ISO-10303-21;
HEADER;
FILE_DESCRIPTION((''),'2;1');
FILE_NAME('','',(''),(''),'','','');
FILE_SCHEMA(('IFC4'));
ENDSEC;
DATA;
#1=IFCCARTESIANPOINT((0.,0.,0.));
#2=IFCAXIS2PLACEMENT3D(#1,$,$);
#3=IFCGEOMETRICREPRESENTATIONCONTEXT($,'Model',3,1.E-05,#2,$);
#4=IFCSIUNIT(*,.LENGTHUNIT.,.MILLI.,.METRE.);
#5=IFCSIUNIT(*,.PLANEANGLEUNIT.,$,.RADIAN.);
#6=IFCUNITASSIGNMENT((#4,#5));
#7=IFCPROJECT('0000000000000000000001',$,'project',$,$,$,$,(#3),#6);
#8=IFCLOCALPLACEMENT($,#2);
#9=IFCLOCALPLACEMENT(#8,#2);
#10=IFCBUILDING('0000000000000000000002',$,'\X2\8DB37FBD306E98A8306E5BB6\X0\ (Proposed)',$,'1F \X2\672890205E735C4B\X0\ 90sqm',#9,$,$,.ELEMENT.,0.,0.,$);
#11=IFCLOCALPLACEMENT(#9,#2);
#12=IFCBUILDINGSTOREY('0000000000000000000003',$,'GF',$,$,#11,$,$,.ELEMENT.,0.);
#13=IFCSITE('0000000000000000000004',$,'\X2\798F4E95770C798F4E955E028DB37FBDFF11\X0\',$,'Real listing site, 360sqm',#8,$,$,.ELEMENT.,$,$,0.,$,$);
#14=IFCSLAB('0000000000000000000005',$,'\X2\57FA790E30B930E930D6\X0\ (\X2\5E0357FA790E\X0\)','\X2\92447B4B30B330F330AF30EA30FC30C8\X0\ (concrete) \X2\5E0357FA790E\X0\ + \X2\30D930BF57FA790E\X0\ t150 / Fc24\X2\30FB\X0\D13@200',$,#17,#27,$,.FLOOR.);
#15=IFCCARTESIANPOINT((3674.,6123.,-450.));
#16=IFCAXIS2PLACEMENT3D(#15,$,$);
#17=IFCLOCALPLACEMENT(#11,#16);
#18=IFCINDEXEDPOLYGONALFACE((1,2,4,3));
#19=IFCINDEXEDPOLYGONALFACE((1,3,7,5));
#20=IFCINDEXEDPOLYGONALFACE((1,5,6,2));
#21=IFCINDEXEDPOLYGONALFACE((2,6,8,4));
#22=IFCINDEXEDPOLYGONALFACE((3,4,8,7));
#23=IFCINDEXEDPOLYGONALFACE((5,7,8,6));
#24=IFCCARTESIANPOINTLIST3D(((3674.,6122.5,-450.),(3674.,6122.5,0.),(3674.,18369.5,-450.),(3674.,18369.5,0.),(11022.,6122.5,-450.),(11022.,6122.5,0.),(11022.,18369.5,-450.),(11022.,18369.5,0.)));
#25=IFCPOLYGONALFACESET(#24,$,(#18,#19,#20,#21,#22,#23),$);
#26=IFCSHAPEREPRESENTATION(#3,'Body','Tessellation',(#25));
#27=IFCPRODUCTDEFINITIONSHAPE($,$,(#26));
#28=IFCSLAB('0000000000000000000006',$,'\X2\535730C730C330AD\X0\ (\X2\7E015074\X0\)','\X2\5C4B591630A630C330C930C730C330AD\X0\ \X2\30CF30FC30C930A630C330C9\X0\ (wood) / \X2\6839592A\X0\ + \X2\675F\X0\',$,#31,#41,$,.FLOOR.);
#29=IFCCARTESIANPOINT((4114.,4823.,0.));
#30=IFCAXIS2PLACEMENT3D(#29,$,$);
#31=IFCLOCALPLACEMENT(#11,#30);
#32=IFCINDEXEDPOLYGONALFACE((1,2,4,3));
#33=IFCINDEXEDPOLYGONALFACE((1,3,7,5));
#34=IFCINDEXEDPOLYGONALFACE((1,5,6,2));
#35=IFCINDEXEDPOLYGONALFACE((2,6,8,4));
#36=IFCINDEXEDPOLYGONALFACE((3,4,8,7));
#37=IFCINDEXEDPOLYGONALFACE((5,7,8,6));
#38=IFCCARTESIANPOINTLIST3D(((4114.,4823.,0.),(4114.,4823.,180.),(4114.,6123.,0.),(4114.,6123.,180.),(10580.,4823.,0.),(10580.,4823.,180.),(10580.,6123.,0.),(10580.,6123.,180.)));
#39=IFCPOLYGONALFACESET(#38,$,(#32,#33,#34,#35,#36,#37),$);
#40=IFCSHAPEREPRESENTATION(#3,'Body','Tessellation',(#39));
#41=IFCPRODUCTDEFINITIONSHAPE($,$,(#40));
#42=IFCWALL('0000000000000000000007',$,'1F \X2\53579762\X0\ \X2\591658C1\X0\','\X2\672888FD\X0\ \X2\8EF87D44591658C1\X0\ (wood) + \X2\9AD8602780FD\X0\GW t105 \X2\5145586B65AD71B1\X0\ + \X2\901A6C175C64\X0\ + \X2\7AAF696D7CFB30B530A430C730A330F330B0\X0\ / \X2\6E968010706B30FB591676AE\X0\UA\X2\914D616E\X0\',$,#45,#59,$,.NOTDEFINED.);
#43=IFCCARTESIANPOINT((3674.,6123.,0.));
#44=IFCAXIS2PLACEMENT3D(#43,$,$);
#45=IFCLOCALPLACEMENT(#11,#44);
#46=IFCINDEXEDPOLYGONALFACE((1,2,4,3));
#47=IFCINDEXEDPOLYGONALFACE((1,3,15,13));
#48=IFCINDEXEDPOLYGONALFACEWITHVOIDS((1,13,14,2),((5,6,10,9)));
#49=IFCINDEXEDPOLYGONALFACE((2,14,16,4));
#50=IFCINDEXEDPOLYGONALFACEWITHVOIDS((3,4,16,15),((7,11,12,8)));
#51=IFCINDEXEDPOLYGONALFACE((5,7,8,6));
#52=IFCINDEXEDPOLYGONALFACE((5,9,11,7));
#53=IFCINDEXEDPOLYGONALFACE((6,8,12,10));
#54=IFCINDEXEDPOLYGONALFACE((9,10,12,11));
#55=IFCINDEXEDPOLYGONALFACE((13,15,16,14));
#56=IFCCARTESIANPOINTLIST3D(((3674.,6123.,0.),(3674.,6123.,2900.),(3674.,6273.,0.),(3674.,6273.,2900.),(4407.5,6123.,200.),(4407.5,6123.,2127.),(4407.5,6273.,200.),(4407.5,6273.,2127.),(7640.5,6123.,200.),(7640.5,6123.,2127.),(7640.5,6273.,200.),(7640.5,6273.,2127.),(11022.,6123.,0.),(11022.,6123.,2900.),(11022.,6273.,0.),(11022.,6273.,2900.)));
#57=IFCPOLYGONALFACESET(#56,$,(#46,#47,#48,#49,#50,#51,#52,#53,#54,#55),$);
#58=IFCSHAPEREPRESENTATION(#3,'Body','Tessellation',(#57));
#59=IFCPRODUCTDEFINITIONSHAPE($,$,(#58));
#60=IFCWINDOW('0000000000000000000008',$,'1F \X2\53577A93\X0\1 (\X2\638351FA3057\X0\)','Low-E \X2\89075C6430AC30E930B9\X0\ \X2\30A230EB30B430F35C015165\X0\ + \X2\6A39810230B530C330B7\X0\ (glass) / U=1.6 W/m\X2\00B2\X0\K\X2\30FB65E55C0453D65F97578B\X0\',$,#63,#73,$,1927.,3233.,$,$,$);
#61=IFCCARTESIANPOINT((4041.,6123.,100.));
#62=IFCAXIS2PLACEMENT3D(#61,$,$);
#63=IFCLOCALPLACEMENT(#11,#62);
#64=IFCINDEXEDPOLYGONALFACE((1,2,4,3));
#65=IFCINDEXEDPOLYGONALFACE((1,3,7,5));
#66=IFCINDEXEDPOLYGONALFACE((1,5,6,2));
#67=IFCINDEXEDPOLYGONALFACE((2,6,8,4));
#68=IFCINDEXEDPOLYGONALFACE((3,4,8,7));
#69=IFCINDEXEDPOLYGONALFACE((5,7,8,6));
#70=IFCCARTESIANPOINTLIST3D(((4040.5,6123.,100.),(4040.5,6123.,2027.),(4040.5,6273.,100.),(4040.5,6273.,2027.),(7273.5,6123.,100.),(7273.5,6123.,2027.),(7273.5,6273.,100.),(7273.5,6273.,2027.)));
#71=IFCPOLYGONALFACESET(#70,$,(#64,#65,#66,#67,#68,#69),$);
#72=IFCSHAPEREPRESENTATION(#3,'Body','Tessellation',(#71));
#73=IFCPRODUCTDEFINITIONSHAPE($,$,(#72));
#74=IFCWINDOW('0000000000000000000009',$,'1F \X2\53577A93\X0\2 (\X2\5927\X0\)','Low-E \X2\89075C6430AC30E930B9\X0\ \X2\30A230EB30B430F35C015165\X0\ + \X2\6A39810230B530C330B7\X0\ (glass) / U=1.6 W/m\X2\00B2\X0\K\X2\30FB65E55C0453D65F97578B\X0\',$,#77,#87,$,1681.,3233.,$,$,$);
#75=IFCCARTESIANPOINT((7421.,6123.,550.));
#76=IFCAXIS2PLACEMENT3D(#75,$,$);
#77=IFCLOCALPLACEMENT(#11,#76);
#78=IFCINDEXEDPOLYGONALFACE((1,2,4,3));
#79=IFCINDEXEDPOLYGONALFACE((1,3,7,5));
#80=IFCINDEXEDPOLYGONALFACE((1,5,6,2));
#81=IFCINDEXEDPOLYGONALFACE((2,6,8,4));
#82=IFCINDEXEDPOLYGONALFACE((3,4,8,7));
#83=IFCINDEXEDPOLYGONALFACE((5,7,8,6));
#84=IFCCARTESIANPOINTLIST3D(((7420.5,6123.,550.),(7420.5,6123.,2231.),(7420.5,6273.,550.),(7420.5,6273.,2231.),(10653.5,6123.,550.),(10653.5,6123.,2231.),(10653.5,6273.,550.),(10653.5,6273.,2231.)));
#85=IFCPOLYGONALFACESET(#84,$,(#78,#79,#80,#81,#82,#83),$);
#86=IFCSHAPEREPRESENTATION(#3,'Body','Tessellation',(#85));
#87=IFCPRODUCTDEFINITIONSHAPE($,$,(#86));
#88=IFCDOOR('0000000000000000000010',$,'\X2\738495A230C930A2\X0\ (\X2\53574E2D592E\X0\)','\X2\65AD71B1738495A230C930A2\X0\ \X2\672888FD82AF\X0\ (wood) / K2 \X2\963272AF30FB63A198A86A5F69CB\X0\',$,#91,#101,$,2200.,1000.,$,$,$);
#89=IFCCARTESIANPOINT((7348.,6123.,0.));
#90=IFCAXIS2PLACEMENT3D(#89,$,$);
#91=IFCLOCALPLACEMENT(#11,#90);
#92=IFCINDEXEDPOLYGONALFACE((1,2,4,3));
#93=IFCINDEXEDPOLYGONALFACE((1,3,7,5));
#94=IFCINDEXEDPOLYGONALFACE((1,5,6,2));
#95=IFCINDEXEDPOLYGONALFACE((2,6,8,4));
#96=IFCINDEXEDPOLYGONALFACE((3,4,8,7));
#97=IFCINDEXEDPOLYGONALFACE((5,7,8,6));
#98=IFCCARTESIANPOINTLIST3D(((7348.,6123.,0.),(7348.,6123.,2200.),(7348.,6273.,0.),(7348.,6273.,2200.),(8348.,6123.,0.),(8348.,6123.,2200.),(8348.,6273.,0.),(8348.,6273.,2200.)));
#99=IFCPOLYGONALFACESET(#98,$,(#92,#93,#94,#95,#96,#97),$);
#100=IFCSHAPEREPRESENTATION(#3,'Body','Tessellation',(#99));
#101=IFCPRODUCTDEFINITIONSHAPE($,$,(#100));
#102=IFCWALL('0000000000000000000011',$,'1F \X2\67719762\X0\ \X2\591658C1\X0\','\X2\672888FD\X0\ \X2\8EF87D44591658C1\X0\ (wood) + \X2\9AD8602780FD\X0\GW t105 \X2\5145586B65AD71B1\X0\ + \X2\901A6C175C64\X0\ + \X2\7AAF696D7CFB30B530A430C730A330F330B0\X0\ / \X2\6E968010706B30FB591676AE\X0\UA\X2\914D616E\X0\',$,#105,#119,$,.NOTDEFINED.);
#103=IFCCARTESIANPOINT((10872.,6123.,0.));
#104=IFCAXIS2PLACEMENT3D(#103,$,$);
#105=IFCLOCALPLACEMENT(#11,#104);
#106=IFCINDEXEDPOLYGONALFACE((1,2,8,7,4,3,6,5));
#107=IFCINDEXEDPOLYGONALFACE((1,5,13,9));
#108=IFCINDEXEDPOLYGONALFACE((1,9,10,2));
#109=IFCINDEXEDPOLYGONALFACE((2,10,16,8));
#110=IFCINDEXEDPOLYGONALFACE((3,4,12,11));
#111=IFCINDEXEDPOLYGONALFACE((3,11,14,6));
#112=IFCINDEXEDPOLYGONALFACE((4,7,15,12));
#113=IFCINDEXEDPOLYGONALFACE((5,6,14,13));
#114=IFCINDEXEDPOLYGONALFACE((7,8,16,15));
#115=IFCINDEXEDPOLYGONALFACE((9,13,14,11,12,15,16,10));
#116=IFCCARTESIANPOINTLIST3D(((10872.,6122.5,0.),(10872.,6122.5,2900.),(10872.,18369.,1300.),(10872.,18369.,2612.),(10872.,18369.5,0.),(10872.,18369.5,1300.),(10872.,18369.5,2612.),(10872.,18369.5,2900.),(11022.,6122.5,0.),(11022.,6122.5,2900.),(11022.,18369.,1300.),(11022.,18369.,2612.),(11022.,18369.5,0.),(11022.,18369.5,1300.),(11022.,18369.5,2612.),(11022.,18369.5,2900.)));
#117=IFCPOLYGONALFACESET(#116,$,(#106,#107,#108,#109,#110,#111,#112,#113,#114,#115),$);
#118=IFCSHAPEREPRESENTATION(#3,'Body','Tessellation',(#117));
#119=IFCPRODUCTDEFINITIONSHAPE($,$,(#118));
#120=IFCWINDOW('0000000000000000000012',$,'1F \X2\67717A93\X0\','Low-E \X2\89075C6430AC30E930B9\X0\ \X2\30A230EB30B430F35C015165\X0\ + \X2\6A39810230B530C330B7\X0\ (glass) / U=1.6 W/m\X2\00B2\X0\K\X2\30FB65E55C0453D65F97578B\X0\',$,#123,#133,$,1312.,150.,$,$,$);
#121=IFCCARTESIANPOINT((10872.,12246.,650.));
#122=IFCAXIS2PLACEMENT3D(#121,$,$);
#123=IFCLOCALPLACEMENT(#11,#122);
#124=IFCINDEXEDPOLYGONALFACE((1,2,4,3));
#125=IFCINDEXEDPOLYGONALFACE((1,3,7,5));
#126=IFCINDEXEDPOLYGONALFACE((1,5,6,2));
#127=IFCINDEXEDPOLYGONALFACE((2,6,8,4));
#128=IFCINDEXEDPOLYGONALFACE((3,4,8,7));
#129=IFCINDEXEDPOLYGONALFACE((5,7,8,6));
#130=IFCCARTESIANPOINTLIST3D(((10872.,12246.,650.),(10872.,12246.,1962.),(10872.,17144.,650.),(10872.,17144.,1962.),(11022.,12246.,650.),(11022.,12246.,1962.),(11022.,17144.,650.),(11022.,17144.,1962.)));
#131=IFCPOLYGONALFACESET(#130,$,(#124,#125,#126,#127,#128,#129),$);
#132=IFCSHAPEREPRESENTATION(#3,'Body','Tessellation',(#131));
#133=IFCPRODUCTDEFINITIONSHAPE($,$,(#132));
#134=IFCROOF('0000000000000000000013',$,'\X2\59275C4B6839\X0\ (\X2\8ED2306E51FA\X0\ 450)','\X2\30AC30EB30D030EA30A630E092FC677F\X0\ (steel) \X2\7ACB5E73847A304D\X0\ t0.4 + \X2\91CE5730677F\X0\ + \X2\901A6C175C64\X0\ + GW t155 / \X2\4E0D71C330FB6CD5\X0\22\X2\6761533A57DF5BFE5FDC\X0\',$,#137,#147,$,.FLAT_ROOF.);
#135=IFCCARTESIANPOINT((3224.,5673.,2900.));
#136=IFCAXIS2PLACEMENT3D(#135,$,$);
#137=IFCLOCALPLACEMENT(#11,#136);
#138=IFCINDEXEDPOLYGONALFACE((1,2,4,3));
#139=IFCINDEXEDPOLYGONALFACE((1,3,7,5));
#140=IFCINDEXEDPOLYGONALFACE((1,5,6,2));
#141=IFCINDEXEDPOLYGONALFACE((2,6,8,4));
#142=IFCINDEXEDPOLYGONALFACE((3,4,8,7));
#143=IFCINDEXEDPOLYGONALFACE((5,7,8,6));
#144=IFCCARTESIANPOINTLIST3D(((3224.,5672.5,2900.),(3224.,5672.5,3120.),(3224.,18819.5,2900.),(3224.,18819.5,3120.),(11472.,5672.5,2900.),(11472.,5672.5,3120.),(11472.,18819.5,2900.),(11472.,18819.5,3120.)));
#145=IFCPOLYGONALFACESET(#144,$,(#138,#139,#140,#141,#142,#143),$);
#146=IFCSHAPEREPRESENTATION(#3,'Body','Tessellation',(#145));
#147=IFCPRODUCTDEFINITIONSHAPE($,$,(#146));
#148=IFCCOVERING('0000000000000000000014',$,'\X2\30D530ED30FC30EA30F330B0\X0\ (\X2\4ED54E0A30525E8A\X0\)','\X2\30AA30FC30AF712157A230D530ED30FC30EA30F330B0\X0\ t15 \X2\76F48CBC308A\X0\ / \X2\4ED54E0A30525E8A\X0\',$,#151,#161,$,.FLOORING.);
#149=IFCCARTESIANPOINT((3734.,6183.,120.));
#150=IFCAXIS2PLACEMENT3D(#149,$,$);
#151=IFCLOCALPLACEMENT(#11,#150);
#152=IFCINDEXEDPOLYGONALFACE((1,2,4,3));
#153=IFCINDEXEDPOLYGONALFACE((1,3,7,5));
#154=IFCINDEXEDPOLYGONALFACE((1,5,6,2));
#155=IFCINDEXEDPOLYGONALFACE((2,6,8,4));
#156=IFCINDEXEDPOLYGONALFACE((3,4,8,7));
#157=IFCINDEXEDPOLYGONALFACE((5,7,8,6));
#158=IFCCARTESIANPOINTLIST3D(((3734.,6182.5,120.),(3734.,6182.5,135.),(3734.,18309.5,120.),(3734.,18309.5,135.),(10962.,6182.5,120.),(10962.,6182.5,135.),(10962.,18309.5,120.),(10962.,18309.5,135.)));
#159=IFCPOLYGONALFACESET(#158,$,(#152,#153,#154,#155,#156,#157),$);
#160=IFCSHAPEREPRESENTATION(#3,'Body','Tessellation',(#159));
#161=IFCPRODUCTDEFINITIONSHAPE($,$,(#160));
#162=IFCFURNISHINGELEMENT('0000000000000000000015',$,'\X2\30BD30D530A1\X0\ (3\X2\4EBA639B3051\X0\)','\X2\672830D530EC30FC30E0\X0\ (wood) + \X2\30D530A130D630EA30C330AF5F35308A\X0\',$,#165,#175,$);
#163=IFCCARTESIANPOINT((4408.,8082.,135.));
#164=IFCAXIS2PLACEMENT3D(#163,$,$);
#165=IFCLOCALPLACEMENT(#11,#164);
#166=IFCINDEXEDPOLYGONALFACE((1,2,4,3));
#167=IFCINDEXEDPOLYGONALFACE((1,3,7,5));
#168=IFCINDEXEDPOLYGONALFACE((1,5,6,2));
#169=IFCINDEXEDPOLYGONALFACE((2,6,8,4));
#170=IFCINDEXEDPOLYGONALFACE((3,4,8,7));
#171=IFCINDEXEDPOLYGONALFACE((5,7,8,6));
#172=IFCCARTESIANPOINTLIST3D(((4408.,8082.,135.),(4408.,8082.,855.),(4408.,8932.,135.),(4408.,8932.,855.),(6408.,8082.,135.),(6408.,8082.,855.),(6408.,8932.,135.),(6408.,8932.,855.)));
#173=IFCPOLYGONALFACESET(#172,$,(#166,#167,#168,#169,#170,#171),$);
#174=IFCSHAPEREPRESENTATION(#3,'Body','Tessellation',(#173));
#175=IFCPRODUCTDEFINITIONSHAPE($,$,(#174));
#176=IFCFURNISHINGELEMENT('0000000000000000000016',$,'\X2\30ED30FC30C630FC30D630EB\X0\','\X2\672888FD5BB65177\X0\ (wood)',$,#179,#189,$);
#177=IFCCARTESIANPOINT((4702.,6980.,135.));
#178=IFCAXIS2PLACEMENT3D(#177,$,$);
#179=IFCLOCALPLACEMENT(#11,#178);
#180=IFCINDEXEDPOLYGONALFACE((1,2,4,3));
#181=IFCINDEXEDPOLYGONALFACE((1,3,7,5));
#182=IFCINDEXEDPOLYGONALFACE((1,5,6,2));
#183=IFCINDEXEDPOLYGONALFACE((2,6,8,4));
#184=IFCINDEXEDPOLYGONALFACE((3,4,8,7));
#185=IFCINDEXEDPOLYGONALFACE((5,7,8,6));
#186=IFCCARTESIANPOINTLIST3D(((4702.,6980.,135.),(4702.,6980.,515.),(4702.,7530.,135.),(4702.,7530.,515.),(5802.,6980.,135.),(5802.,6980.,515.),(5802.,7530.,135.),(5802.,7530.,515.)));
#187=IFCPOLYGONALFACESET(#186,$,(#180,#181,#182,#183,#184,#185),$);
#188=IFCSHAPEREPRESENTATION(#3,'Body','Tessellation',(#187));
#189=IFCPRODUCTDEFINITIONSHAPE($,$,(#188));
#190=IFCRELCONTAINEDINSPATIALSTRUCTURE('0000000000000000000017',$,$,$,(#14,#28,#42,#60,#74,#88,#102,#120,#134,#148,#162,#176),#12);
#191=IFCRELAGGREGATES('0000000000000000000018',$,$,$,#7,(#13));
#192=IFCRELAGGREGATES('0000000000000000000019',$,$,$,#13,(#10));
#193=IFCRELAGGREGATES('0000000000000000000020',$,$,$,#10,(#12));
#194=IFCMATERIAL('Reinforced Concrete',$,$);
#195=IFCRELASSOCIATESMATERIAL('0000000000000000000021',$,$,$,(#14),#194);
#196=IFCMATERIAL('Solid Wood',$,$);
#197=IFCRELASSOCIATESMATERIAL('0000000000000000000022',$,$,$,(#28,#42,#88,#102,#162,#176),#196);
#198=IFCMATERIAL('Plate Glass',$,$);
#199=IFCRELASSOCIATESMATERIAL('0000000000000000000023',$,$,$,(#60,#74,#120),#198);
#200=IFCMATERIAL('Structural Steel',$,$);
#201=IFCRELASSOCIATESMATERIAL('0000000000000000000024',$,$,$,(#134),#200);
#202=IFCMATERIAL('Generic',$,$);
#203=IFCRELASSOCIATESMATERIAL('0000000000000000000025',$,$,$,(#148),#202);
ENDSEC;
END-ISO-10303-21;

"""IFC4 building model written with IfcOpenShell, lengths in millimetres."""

from ifc_helpers import new_model, si_unit, frame, frame_2d, origin, place, context, project, spatial, rectangle, extrude, material, element, fill, save


model = new_model("IFC4")

# Units and contexts
model_context = context("Model", 3, precision=1e-05, world=origin())
ifc_project = project(units=[si_unit("LENGTHUNIT", "METRE", prefix="MILLI"), si_unit("PLANEANGLEUNIT", "RADIAN")], contexts=[model_context])

# Site, building, storey
site_placement = place(None, origin())
site = spatial("IfcSite", under=ifc_project, at=site_placement, Name="福井県福井市足羽１", ObjectType="Real listing site, 360sqm", CompositionType="ELEMENT", RefElevation=0.0)
building_placement = place(site_placement, origin())
building = spatial("IfcBuilding", under=site, at=building_placement, Name="足羽の風の家 (Proposed)", ObjectType="1F 木造平屋 90sqm", CompositionType="ELEMENT", ElevationOfRefHeight=0.0, ElevationOfTerrain=0.0)
storey_placement = place(building_placement, origin())
storey = spatial("IfcBuildingStorey", under=building, at=storey_placement, Name="GF", CompositionType="ELEMENT", Elevation=0.0)

# Slabs
ifc_material_1 = material(Name="Reinforced Concrete")
slab_1_placement = place(storey_placement, frame((3674.0, 6123.0, -450.0)))
element("IfcSlab", 1, at=slab_1_placement, inside=storey, material=ifc_material_1, Name="基礎スラブ (布基礎)", Description="鉄筋コンクリート (concrete) 布基礎 + ベタ基礎 t150 / Fc24・D13@200", PredefinedType="FLOOR", context=model_context, shape_type="SweptSolid", body=[
    extrude(rectangle(XDim=7348.0, YDim=12247.0, at=frame_2d((3674.0, 6123.0))), frame((3674.0, 6123.0, -450.0)), (0.0, 0.0, 1.0), 450.0),
])
ifc_material_2 = material(Name="Solid Wood")
slab_2_placement = place(storey_placement, frame((4114.0, 4823.0, 0.0)))
element("IfcSlab", 2, at=slab_2_placement, inside=storey, material=ifc_material_2, Name="南デッキ (縁側)", Description="屋外ウッドデッキ ハードウッド (wood) / 根太 + 束", PredefinedType="FLOOR", context=model_context, shape_type="SweptSolid", body=[
    extrude(rectangle(XDim=6466.0, YDim=1300.0, at=frame_2d((3233.0, 650.0))), frame((4114.0, 4823.0, 0.0)), (0.0, 0.0, 1.0), 180.0),
])

# Wall, openings, windows, door
wall_1_placement = place(storey_placement, frame((3674.0, 6123.0, 0.0)))
wall_1 = element("IfcWall", 3, at=wall_1_placement, inside=storey, material=ifc_material_2, Name="1F 南面 外壁", Description="木製 軸組外壁 (wood) + 高性能GW t105 充填断熱 + 通気層 + 窯業系サイディング / 準耐火・外皮UA配慮", PredefinedType="NOTDEFINED", context=model_context, shape_type="SweptSolid", body=[
    extrude(rectangle(XDim=7348.0, YDim=150.0, at=frame_2d((3674.0, 75.0))), frame((3674.0, 6123.0, 0.0)), (0.0, 0.0, 1.0), 2900.0),
])
opening_1_placement = place(storey_placement, frame((4041.0, 6123.0, 100.0)))
opening_1 = element("IfcOpeningElement", 4, at=opening_1_placement, cuts=wall_1, PredefinedType="NOTDEFINED", context=model_context, shape_type="SweptSolid", body=[
    extrude(rectangle(XDim=3233.0, YDim=150.0, at=frame_2d((1616.0, 75.0))), frame((4041.0, 6123.0, 100.0)), (0.0, 0.0, 1.0), 1927.0),
])
opening_2_placement = place(storey_placement, frame((7421.0, 6123.0, 550.0)))
opening_2 = element("IfcOpeningElement", 5, at=opening_2_placement, cuts=wall_1, PredefinedType="NOTDEFINED", context=model_context, shape_type="SweptSolid", body=[
    extrude(rectangle(XDim=3233.0, YDim=150.0, at=frame_2d((1616.0, 75.0))), frame((7421.0, 6123.0, 550.0)), (0.0, 0.0, 1.0), 1681.0),
])
opening_3_placement = place(storey_placement, frame((7348.0, 6123.0, 0.0)))
opening_3 = element("IfcOpeningElement", 6, at=opening_3_placement, cuts=wall_1, PredefinedType="NOTDEFINED", context=model_context, shape_type="SweptSolid", body=[
    extrude(rectangle(XDim=1000.0, YDim=150.0, at=frame_2d((500.0, 75.0))), frame((7348.0, 6123.0, 0.0)), (0.0, 0.0, 1.0), 2200.0),
])
ifc_material_3 = material(Name="Plate Glass")
window_1_placement = place(storey_placement, frame((4041.0, 6123.0, 100.0)))
window_1 = element("IfcWindow", 7, at=window_1_placement, inside=storey, material=ifc_material_3, Name="1F 南窓1 (掃出し)", Description="Low-E 複層ガラス アルゴン封入 + 樹脂サッシ (glass) / U=1.6 W/m²K・日射取得型", OverallHeight=1927.0, OverallWidth=3233.0, context=model_context, shape_type="SweptSolid", body=[
    extrude(rectangle(XDim=3233.0, YDim=150.0, at=frame_2d((1616.0, 75.0))), frame((4041.0, 6123.0, 100.0)), (0.0, 0.0, 1.0), 1927.0),
])
fill(opening_1, window_1)
window_2_placement = place(storey_placement, frame((7421.0, 6123.0, 550.0)))
window_2 = element("IfcWindow", 8, at=window_2_placement, inside=storey, material=ifc_material_3, Name="1F 南窓2 (大)", Description="Low-E 複層ガラス アルゴン封入 + 樹脂サッシ (glass) / U=1.6 W/m²K・日射取得型", OverallHeight=1681.0, OverallWidth=3233.0, context=model_context, shape_type="SweptSolid", body=[
    extrude(rectangle(XDim=3233.0, YDim=150.0, at=frame_2d((1616.0, 75.0))), frame((7421.0, 6123.0, 550.0)), (0.0, 0.0, 1.0), 1681.0),
])
fill(opening_2, window_2)
door_placement = place(storey_placement, frame((7348.0, 6123.0, 0.0)))
door = element("IfcDoor", 9, at=door_placement, inside=storey, material=ifc_material_2, Name="玄関ドア (南中央)", Description="断熱玄関ドア 木製芯 (wood) / K2 防犯・採風機構", OverallHeight=2200.0, OverallWidth=1000.0, context=model_context, shape_type="SweptSolid", body=[
    extrude(rectangle(XDim=1000.0, YDim=150.0, at=frame_2d((500.0, 75.0))), frame((7348.0, 6123.0, 0.0)), (0.0, 0.0, 1.0), 2200.0),
])
fill(opening_3, door)

# Wall, opening, window
wall_2_placement = place(storey_placement, frame((10872.0, 6123.0, 0.0)))
wall_2 = element("IfcWall", 10, at=wall_2_placement, inside=storey, material=ifc_material_2, Name="1F 東面 外壁", Description="木製 軸組外壁 (wood) + 高性能GW t105 充填断熱 + 通気層 + 窯業系サイディング / 準耐火・外皮UA配慮", PredefinedType="NOTDEFINED", context=model_context, shape_type="SweptSolid", body=[
    extrude(rectangle(XDim=150.0, YDim=12247.0, at=frame_2d((75.0, 6123.0))), frame((10872.0, 6123.0, 0.0)), (0.0, 0.0, 1.0), 2900.0),
])
opening_4_placement = place(storey_placement, frame((10872.0, 12246.0, 650.0)))
opening_4 = element("IfcOpeningElement", 11, at=opening_4_placement, cuts=wall_2, PredefinedType="NOTDEFINED", context=model_context, shape_type="SweptSolid", body=[
    extrude(rectangle(XDim=150.0, YDim=4898.0, at=frame_2d((75.0, 2449.0))), frame((10872.0, 12246.0, 650.0)), (0.0, 0.0, 1.0), 1312.0),
])
window_3_placement = place(storey_placement, frame((10872.0, 12246.0, 650.0)))
window_3 = element("IfcWindow", 12, at=window_3_placement, inside=storey, material=ifc_material_3, Name="1F 東窓", Description="Low-E 複層ガラス アルゴン封入 + 樹脂サッシ (glass) / U=1.6 W/m²K・日射取得型", OverallHeight=1312.0, OverallWidth=150.0, context=model_context, shape_type="SweptSolid", body=[
    extrude(rectangle(XDim=150.0, YDim=4898.0, at=frame_2d((75.0, 2449.0))), frame((10872.0, 12246.0, 650.0)), (0.0, 0.0, 1.0), 1312.0),
])
fill(opening_4, window_3)

# Roof
ifc_material_4 = material(Name="Structural Steel")
roof_placement = place(storey_placement, frame((3224.0, 5673.0, 2900.0)))
element("IfcRoof", 13, at=roof_placement, inside=storey, material=ifc_material_4, Name="大屋根 (軒の出 450)", Description="ガルバリウム鋼板 (steel) 立平葺き t0.4 + 野地板 + 通気層 + GW t155 / 不燃・法22条区域対応", PredefinedType="FLAT_ROOF", context=model_context, shape_type="SweptSolid", body=[
    extrude(rectangle(XDim=8248.0, YDim=13147.0, at=frame_2d((4124.0, 6573.0))), frame((3224.0, 5673.0, 2900.0)), (0.0, 0.0, 1.0), 220.0),
])

# Covering
ifc_material_5 = material(Name="Generic")
covering_placement = place(storey_placement, frame((3734.0, 6183.0, 120.0)))
element("IfcCovering", 14, at=covering_placement, inside=storey, material=ifc_material_5, Name="フローリング (仕上げ床)", Description="オーク無垢フローリング t15 直貼り / 仕上げ床", PredefinedType="FLOORING", context=model_context, shape_type="SweptSolid", body=[
    extrude(rectangle(XDim=7228.0, YDim=12127.0, at=frame_2d((3614.0, 6063.0))), frame((3734.0, 6183.0, 120.0)), (0.0, 0.0, 1.0), 15.0),
])

# Furnishing elements
furnishing_1_placement = place(storey_placement, frame((4408.0, 8082.0, 135.0)))
element("IfcFurnishingElement", 15, at=furnishing_1_placement, inside=storey, material=ifc_material_2, Name="ソファ (3人掛け)", Description="木フレーム (wood) + ファブリック張り", context=model_context, shape_type="SweptSolid", body=[
    extrude(rectangle(XDim=2000.0, YDim=850.0, at=frame_2d((1000.0, 425.0))), frame((4408.0, 8082.0, 135.0)), (0.0, 0.0, 1.0), 720.0),
])
furnishing_2_placement = place(storey_placement, frame((4702.0, 6980.0, 135.0)))
element("IfcFurnishingElement", 16, at=furnishing_2_placement, inside=storey, material=ifc_material_2, Name="ローテーブル", Description="木製家具 (wood)", context=model_context, shape_type="SweptSolid", body=[
    extrude(rectangle(XDim=1100.0, YDim=550.0, at=frame_2d((550.0, 275.0))), frame((4702.0, 6980.0, 135.0)), (0.0, 0.0, 1.0), 380.0),
])

save(model, "model.ifc")
